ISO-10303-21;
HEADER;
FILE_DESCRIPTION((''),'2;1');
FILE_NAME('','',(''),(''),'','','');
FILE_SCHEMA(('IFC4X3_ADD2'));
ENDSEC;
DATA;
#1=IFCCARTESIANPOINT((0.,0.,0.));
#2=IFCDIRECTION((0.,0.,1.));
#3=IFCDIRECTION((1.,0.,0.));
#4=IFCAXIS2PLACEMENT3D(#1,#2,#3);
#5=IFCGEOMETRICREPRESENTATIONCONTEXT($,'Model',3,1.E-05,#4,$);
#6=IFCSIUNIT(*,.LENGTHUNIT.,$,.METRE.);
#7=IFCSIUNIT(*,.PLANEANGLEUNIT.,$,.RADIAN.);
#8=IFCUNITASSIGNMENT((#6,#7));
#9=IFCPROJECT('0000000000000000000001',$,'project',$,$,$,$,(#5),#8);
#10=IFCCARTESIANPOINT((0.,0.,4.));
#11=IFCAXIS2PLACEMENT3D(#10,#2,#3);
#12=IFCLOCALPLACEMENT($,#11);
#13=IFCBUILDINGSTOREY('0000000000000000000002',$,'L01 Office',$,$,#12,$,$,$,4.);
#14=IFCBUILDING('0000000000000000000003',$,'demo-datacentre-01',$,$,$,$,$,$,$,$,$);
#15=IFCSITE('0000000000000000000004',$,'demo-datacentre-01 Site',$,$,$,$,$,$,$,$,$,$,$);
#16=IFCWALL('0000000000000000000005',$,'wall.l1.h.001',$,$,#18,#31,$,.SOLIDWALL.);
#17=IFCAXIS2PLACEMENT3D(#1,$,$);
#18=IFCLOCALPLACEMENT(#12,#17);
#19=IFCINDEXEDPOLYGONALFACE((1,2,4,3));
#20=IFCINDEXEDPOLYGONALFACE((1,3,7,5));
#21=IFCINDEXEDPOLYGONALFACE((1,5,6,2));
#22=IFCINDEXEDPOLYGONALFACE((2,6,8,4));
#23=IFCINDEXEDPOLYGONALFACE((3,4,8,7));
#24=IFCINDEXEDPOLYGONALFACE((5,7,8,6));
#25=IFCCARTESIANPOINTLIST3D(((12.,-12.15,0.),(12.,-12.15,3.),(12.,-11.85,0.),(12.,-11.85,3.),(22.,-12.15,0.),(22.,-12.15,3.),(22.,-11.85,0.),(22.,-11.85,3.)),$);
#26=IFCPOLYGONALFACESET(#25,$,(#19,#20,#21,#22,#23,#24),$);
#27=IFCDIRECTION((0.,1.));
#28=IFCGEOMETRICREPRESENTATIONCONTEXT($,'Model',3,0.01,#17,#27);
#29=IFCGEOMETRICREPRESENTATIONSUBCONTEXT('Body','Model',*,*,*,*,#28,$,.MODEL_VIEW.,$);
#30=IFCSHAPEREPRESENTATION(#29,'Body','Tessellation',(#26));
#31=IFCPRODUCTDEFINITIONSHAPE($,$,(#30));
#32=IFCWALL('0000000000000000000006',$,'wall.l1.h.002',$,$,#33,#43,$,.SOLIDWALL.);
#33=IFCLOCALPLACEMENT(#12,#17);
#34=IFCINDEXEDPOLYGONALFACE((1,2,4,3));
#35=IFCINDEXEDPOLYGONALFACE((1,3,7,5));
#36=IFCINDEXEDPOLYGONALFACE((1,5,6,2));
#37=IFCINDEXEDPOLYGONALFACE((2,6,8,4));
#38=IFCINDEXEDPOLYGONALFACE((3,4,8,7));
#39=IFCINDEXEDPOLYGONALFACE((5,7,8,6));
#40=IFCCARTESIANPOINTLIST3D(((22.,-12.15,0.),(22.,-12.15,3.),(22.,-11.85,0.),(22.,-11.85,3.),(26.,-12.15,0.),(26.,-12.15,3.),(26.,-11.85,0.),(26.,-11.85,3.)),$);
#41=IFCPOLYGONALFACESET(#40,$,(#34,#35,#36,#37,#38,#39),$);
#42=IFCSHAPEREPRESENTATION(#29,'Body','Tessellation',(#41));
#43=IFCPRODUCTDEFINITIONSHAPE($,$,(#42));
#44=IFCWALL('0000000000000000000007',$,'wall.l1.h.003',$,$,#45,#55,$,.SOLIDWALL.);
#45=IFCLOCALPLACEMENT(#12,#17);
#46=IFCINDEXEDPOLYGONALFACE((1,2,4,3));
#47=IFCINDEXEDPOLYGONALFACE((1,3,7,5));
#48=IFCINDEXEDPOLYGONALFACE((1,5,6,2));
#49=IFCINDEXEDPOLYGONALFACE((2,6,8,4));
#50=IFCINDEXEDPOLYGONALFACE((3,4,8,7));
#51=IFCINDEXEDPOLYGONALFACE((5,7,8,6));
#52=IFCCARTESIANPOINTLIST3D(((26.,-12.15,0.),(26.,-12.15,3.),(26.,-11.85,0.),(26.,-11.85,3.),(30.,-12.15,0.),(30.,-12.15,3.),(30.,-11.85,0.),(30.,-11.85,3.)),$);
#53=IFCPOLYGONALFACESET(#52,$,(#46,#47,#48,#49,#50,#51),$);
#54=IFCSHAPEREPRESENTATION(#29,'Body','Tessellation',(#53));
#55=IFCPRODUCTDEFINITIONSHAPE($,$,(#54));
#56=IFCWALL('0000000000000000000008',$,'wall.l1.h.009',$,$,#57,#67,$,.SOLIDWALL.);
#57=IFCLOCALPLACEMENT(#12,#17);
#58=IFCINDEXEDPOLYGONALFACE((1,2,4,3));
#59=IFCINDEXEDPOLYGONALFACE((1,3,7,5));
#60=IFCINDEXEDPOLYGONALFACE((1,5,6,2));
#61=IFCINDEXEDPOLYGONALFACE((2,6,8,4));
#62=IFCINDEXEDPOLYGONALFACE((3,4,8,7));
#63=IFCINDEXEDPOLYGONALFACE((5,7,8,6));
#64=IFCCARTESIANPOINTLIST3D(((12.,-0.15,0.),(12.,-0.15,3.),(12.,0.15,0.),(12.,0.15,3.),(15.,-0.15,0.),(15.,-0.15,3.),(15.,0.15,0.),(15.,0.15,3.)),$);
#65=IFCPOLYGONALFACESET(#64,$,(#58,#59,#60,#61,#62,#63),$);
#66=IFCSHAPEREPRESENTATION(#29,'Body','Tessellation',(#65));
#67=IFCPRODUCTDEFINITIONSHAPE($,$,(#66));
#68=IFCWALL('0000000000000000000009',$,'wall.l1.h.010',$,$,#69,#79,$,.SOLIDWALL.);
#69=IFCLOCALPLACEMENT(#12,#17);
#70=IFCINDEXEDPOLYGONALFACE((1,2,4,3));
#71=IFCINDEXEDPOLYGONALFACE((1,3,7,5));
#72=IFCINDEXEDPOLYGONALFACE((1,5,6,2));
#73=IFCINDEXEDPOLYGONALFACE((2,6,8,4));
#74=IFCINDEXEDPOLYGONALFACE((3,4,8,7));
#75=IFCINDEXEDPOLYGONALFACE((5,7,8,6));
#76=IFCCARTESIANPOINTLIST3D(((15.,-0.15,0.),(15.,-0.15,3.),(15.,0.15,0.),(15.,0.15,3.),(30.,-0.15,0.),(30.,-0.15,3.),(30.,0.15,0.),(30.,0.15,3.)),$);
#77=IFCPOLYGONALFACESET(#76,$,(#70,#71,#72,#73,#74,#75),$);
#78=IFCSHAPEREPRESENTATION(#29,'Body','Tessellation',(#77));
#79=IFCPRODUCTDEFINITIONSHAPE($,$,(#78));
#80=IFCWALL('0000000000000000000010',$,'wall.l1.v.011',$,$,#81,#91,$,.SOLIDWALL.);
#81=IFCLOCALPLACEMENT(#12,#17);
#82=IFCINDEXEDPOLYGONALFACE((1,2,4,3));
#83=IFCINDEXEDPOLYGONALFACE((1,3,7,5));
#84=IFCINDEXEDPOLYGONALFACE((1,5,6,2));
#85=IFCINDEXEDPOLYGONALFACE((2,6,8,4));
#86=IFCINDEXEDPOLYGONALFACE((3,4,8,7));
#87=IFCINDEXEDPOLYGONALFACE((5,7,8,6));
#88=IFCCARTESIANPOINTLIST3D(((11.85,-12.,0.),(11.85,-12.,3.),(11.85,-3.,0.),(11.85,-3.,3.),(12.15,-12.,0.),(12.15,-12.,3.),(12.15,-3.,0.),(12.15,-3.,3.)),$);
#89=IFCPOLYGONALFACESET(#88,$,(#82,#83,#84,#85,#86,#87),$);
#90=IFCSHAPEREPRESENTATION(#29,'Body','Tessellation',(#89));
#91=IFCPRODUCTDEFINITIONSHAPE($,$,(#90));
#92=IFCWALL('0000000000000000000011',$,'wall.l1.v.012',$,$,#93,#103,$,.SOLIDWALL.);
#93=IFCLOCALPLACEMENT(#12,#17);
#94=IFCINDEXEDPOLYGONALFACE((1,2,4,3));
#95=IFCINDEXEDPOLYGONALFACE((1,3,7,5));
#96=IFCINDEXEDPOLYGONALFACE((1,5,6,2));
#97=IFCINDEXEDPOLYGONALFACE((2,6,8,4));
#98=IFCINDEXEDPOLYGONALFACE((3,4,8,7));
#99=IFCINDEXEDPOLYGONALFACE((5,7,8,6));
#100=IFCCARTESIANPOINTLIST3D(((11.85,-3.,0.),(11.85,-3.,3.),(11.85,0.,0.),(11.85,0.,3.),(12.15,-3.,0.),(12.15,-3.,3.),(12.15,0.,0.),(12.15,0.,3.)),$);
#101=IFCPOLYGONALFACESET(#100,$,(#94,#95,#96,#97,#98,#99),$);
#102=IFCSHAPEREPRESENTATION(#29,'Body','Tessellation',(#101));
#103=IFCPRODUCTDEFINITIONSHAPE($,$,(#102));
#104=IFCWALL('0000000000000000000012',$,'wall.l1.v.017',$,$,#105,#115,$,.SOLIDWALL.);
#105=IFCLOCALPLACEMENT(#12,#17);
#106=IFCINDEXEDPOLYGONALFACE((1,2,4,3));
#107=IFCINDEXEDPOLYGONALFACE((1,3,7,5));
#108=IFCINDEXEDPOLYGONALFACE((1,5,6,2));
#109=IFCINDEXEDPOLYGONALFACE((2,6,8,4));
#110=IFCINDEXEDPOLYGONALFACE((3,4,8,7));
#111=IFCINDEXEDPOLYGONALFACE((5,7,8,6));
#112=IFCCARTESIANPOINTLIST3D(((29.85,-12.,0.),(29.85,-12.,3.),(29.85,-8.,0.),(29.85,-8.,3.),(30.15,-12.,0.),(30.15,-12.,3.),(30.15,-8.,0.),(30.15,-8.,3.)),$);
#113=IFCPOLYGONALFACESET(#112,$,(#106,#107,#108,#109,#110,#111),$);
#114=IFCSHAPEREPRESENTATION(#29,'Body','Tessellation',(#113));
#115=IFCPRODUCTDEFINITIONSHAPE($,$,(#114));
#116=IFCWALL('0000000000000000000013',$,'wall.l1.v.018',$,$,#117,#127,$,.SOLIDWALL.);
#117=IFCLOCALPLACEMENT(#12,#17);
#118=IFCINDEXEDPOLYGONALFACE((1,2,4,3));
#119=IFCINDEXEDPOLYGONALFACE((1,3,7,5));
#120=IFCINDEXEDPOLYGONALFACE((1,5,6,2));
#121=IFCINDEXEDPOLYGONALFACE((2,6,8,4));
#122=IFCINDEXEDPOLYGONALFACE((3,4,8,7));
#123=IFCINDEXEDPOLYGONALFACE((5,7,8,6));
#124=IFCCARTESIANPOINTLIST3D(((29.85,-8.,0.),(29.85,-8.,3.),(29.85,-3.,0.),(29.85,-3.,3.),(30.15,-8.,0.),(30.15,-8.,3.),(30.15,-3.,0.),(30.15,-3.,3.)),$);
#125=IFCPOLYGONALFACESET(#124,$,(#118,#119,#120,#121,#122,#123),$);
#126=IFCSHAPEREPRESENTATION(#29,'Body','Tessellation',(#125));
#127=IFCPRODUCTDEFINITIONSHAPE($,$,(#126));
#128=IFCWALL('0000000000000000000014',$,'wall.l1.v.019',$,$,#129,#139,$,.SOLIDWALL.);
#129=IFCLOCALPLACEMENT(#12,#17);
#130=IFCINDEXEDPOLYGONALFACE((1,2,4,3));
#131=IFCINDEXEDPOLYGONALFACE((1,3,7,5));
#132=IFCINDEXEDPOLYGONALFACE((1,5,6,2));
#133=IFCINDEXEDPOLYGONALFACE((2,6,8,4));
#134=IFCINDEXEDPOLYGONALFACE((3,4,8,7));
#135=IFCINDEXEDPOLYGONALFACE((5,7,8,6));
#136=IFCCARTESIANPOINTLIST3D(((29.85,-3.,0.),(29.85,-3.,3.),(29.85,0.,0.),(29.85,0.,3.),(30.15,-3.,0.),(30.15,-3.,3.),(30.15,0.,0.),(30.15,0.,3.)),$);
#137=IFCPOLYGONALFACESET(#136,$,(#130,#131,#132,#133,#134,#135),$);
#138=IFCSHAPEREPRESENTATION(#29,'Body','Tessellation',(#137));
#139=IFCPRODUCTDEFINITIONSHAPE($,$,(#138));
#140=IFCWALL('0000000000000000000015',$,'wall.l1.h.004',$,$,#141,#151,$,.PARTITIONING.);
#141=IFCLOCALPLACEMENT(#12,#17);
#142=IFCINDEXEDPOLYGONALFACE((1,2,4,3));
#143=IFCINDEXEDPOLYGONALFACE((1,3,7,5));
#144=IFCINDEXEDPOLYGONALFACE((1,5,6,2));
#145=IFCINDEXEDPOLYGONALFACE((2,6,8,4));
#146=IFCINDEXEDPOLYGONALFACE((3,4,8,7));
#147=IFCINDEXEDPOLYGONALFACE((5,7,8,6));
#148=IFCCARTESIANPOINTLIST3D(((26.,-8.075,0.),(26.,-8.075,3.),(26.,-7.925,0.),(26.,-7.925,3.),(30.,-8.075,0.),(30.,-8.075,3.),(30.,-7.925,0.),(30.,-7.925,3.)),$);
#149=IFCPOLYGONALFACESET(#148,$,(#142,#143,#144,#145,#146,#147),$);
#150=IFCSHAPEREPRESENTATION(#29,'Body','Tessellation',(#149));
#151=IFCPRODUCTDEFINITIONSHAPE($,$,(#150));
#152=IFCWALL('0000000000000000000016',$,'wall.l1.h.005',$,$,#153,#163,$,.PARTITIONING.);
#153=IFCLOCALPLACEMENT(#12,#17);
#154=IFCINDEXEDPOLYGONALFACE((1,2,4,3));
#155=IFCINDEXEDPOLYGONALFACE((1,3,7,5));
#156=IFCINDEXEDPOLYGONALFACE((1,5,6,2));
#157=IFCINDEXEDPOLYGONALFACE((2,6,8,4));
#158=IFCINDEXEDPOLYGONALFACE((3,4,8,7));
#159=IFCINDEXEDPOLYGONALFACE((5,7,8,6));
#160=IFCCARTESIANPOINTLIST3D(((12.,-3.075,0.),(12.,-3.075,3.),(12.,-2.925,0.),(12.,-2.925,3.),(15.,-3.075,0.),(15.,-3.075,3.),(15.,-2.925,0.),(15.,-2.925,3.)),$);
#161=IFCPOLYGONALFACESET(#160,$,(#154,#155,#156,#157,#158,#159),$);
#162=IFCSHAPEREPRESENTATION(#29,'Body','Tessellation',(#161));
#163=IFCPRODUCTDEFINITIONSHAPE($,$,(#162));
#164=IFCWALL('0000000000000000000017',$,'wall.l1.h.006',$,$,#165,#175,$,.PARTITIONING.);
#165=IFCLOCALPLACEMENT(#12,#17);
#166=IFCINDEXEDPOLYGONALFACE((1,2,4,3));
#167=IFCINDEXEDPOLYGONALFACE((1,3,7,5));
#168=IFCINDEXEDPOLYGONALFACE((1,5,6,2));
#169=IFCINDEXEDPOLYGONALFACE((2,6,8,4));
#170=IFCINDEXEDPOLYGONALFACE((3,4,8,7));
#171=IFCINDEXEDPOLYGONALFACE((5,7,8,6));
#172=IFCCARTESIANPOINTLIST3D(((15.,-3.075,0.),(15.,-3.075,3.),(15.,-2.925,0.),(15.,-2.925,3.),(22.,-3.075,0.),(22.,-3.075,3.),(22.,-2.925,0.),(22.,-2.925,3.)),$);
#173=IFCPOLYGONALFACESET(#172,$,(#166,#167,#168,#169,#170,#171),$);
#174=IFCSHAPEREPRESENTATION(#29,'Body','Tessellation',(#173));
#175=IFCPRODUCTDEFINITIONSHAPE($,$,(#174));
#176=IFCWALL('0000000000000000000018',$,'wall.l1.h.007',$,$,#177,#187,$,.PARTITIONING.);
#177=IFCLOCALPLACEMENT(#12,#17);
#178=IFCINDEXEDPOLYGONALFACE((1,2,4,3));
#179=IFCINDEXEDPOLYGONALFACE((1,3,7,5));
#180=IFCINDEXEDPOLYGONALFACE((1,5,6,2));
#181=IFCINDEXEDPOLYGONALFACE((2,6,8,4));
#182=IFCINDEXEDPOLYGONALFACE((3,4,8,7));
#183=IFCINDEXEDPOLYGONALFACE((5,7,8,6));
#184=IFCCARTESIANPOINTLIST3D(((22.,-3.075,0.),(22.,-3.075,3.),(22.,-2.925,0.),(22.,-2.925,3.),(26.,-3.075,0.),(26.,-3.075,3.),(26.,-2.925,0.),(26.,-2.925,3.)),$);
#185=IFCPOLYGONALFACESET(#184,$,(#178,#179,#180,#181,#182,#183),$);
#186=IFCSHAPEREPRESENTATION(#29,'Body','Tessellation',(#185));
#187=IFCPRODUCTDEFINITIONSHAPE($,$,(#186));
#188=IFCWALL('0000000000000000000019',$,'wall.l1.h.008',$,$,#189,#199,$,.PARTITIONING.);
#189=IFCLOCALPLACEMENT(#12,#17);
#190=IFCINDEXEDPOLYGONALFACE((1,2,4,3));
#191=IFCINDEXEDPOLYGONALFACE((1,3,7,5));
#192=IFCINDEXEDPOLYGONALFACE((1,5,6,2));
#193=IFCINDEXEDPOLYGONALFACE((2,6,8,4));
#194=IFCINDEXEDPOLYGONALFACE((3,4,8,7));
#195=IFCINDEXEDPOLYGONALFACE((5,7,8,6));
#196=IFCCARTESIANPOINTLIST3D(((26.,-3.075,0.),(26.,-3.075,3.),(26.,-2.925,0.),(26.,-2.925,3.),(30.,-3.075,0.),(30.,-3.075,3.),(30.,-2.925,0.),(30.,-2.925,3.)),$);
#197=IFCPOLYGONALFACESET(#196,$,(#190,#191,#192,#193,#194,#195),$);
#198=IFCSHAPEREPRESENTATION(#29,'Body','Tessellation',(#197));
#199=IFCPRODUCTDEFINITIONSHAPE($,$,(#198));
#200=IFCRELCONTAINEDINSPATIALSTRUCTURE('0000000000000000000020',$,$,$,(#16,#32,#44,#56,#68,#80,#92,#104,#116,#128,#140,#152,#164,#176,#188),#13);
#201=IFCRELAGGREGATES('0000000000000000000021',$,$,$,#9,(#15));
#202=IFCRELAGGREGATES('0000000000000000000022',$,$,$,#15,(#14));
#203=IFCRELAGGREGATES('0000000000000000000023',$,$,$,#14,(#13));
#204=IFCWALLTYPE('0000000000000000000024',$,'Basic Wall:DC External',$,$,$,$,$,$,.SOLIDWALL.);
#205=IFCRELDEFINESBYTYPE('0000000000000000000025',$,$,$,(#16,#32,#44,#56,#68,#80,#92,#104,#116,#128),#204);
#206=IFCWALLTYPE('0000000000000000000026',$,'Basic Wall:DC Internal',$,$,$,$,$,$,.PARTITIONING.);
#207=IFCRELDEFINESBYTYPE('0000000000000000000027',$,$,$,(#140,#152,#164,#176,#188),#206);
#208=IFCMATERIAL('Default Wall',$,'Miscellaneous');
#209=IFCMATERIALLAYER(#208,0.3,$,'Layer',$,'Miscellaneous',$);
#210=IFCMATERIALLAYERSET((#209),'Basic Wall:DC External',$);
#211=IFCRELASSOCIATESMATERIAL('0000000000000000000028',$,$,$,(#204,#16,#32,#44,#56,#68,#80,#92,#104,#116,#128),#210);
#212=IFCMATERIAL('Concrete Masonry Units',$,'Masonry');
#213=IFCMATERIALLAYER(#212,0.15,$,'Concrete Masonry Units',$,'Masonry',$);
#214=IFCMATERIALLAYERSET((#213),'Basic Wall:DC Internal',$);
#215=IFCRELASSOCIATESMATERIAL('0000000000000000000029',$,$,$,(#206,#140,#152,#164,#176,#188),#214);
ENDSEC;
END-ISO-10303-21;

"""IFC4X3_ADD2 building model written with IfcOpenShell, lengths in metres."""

from ifc_helpers import new_model, si_unit, direction, frame, frame_2d, origin, origin_with_axes, place, context, subcontext, project, spatial, rectangle, extrude, material, layer, layer_set, type_object, element, save


model = new_model("IFC4X3_ADD2")

# Units and contexts
model_context_1 = context("Model", 3, precision=0.01, world=origin(), true_north=direction((0.0, 1.0)))
model_context_2 = context("Model", 3, precision=1e-05, world=origin_with_axes())
body_context = subcontext(model_context_1, "Body", "Model", "MODEL_VIEW")
ifc_project = project(units=[si_unit("LENGTHUNIT", "METRE"), si_unit("PLANEANGLEUNIT", "RADIAN")], contexts=[model_context_2])

# Site, building, storey
site = spatial("IfcSite", under=ifc_project, Name="demo-datacentre-01 Site")
building = spatial("IfcBuilding", under=site, Name="demo-datacentre-01")
storey_placement = place(None, frame((0.0, 0.0, 4.0), z_axis=(0.0, 0.0, 1.0), x_axis=(1.0, 0.0, 0.0)))
storey = spatial("IfcBuildingStorey", under=building, at=storey_placement, Name="L01 Office", Elevation=4.0)

# Shared definitions
placement_1 = place(None, origin())
placement_2 = place(placement_1, origin())
placement_3 = place(placement_2, frame((0.0, 0.0, 4.0)))

# Walls
ifc_material_1 = material(Name="Default Wall", Category="Miscellaneous")
ifc_layer_1 = layer(ifc_material_1, 0.3, Name="Layer", Category="Miscellaneous")
ifc_layer_set_1 = layer_set([ifc_layer_1], Name="Basic Wall:DC External")
wall_type_1 = type_object("IfcWallType", Name="Basic Wall:DC External", PredefinedType="SOLIDWALL", material=ifc_layer_set_1)
wall_1_placement = place(placement_3, frame((12.0, -12.0, 0.0)))
element("IfcWall", 1, at=wall_1_placement, inside=storey, type_object=wall_type_1, material=ifc_layer_set_1, Name="wall.l1.h.001", PredefinedType="SOLIDWALL", context=body_context, shape_type="SweptSolid", body=[
    extrude(rectangle(XDim=10.0, YDim=0.3, at=frame_2d((5.0, 0.0), x_axis=(-1.0, 0.0))), origin(), (0.0, 0.0, 1.0), 3.0),
])
for number, where, name in (
    (2, (22.0, -12.0, 0.0), "wall.l1.h.002"),
    (3, (26.0, -12.0, 0.0), "wall.l1.h.003"),
):
    element("IfcWall", number, at=place(placement_3, frame(where)), inside=storey, type_object=wall_type_1, material=ifc_layer_set_1, Name=name, PredefinedType="SOLIDWALL", context=body_context, shape_type="SweptSolid", body=[
        extrude(rectangle(XDim=4.0, YDim=0.3, at=frame_2d((2.0, 0.0), x_axis=(-1.0, 0.0))), origin(), (0.0, 0.0, 1.0), 3.0),
    ])
wall_2_placement = place(placement_3, frame((12.0, 0.0, 0.0)))
element("IfcWall", 4, at=wall_2_placement, inside=storey, type_object=wall_type_1, material=ifc_layer_set_1, Name="wall.l1.h.009", PredefinedType="SOLIDWALL", context=body_context, shape_type="SweptSolid", body=[
    extrude(rectangle(XDim=3.0, YDim=0.3, at=frame_2d((1.5, 0.0), x_axis=(-1.0, 0.0))), origin(), (0.0, 0.0, 1.0), 3.0),
])
wall_3_placement = place(placement_3, frame((15.0, 0.0, 0.0)))
element("IfcWall", 5, at=wall_3_placement, inside=storey, type_object=wall_type_1, material=ifc_layer_set_1, Name="wall.l1.h.010", PredefinedType="SOLIDWALL", context=body_context, shape_type="SweptSolid", body=[
    extrude(rectangle(XDim=15.0, YDim=0.3, at=frame_2d((7.5, 0.0), x_axis=(-1.0, 0.0))), origin(), (0.0, 0.0, 1.0), 3.0),
])
wall_4_placement = place(placement_3, frame((12.0, -12.0, 0.0), z_axis=(0.0, 0.0, 1.0), x_axis=(0.0, 1.0, 0.0)))
element("IfcWall", 6, at=wall_4_placement, inside=storey, type_object=wall_type_1, material=ifc_layer_set_1, Name="wall.l1.v.011", PredefinedType="SOLIDWALL", context=body_context, shape_type="SweptSolid", body=[
    extrude(rectangle(XDim=9.0, YDim=0.3, at=frame_2d((4.5, 0.0), x_axis=(-1.0, 0.0))), origin(), (0.0, 0.0, 1.0), 3.0),
])
wall_5_placement = place(placement_3, frame((12.0, -3.0, 0.0), z_axis=(0.0, 0.0, 1.0), x_axis=(0.0, 1.0, 0.0)))
element("IfcWall", 7, at=wall_5_placement, inside=storey, type_object=wall_type_1, material=ifc_layer_set_1, Name="wall.l1.v.012", PredefinedType="SOLIDWALL", context=body_context, shape_type="SweptSolid", body=[
    extrude(rectangle(XDim=3.0, YDim=0.3, at=frame_2d((1.5, 0.0), x_axis=(-1.0, 0.0))), origin(), (0.0, 0.0, 1.0), 3.0),
])
wall_6_placement = place(placement_3, frame((30.0, -12.0, 0.0), z_axis=(0.0, 0.0, 1.0), x_axis=(0.0, 1.0, 0.0)))
element("IfcWall", 8, at=wall_6_placement, inside=storey, type_object=wall_type_1, material=ifc_layer_set_1, Name="wall.l1.v.017", PredefinedType="SOLIDWALL", context=body_context, shape_type="SweptSolid", body=[
    extrude(rectangle(XDim=4.0, YDim=0.3, at=frame_2d((2.0, 0.0), x_axis=(-1.0, 0.0))), origin(), (0.0, 0.0, 1.0), 3.0),
])
wall_7_placement = place(placement_3, frame((30.0, -8.0, 0.0), z_axis=(0.0, 0.0, 1.0), x_axis=(0.0, 1.0, 0.0)))
element("IfcWall", 9, at=wall_7_placement, inside=storey, type_object=wall_type_1, material=ifc_layer_set_1, Name="wall.l1.v.018", PredefinedType="SOLIDWALL", context=body_context, shape_type="SweptSolid", body=[
    extrude(rectangle(XDim=5.0, YDim=0.3, at=frame_2d((2.5, 0.0), x_axis=(-1.0, 0.0))), origin(), (0.0, 0.0, 1.0), 3.0),
])
wall_8_placement = place(placement_3, frame((30.0, -3.0, 0.0), z_axis=(0.0, 0.0, 1.0), x_axis=(0.0, 1.0, 0.0)))
element("IfcWall", 10, at=wall_8_placement, inside=storey, type_object=wall_type_1, material=ifc_layer_set_1, Name="wall.l1.v.019", PredefinedType="SOLIDWALL", context=body_context, shape_type="SweptSolid", body=[
    extrude(rectangle(XDim=3.0, YDim=0.3, at=frame_2d((1.5, 0.0), x_axis=(-1.0, 0.0))), origin(), (0.0, 0.0, 1.0), 3.0),
])
ifc_material_2 = material(Name="Concrete Masonry Units", Category="Masonry")
ifc_layer_2 = layer(ifc_material_2, 0.15, Name="Concrete Masonry Units", Category="Masonry")
ifc_layer_set_2 = layer_set([ifc_layer_2], Name="Basic Wall:DC Internal")
wall_type_2 = type_object("IfcWallType", Name="Basic Wall:DC Internal", PredefinedType="PARTITIONING", material=ifc_layer_set_2)
wall_9_placement = place(placement_3, frame((26.0, -8.0, 0.0)))
element("IfcWall", 11, at=wall_9_placement, inside=storey, type_object=wall_type_2, material=ifc_layer_set_2, Name="wall.l1.h.004", PredefinedType="PARTITIONING", context=body_context, shape_type="SweptSolid", body=[
    extrude(rectangle(XDim=4.0, YDim=0.15, at=frame_2d((2.0, 0.0), x_axis=(-1.0, 0.0))), origin(), (0.0, 0.0, 1.0), 3.0),
])
wall_10_placement = place(placement_3, frame((12.0, -3.0, 0.0)))
element("IfcWall", 12, at=wall_10_placement, inside=storey, type_object=wall_type_2, material=ifc_layer_set_2, Name="wall.l1.h.005", PredefinedType="PARTITIONING", context=body_context, shape_type="SweptSolid", body=[
    extrude(rectangle(XDim=3.0, YDim=0.15, at=frame_2d((1.5, 0.0), x_axis=(-1.0, 0.0))), origin(), (0.0, 0.0, 1.0), 3.0),
])
wall_11_placement = place(placement_3, frame((15.0, -3.0, 0.0)))
element("IfcWall", 13, at=wall_11_placement, inside=storey, type_object=wall_type_2, material=ifc_layer_set_2, Name="wall.l1.h.006", PredefinedType="PARTITIONING", context=body_context, shape_type="SweptSolid", body=[
    extrude(rectangle(XDim=7.0, YDim=0.15, at=frame_2d((3.5, 0.0), x_axis=(-1.0, 0.0))), origin(), (0.0, 0.0, 1.0), 3.0),
])
for number, where, name in (
    (14, (22.0, -3.0, 0.0), "wall.l1.h.007"),
    (15, (26.0, -3.0, 0.0), "wall.l1.h.008"),
):
    element("IfcWall", number, at=place(placement_3, frame(where)), inside=storey, type_object=wall_type_2, material=ifc_layer_set_2, Name=name, PredefinedType="PARTITIONING", context=body_context, shape_type="SweptSolid", body=[
        extrude(rectangle(XDim=4.0, YDim=0.15, at=frame_2d((2.0, 0.0), x_axis=(-1.0, 0.0))), origin(), (0.0, 0.0, 1.0), 3.0),
    ])

save(model, "model.ifc")
